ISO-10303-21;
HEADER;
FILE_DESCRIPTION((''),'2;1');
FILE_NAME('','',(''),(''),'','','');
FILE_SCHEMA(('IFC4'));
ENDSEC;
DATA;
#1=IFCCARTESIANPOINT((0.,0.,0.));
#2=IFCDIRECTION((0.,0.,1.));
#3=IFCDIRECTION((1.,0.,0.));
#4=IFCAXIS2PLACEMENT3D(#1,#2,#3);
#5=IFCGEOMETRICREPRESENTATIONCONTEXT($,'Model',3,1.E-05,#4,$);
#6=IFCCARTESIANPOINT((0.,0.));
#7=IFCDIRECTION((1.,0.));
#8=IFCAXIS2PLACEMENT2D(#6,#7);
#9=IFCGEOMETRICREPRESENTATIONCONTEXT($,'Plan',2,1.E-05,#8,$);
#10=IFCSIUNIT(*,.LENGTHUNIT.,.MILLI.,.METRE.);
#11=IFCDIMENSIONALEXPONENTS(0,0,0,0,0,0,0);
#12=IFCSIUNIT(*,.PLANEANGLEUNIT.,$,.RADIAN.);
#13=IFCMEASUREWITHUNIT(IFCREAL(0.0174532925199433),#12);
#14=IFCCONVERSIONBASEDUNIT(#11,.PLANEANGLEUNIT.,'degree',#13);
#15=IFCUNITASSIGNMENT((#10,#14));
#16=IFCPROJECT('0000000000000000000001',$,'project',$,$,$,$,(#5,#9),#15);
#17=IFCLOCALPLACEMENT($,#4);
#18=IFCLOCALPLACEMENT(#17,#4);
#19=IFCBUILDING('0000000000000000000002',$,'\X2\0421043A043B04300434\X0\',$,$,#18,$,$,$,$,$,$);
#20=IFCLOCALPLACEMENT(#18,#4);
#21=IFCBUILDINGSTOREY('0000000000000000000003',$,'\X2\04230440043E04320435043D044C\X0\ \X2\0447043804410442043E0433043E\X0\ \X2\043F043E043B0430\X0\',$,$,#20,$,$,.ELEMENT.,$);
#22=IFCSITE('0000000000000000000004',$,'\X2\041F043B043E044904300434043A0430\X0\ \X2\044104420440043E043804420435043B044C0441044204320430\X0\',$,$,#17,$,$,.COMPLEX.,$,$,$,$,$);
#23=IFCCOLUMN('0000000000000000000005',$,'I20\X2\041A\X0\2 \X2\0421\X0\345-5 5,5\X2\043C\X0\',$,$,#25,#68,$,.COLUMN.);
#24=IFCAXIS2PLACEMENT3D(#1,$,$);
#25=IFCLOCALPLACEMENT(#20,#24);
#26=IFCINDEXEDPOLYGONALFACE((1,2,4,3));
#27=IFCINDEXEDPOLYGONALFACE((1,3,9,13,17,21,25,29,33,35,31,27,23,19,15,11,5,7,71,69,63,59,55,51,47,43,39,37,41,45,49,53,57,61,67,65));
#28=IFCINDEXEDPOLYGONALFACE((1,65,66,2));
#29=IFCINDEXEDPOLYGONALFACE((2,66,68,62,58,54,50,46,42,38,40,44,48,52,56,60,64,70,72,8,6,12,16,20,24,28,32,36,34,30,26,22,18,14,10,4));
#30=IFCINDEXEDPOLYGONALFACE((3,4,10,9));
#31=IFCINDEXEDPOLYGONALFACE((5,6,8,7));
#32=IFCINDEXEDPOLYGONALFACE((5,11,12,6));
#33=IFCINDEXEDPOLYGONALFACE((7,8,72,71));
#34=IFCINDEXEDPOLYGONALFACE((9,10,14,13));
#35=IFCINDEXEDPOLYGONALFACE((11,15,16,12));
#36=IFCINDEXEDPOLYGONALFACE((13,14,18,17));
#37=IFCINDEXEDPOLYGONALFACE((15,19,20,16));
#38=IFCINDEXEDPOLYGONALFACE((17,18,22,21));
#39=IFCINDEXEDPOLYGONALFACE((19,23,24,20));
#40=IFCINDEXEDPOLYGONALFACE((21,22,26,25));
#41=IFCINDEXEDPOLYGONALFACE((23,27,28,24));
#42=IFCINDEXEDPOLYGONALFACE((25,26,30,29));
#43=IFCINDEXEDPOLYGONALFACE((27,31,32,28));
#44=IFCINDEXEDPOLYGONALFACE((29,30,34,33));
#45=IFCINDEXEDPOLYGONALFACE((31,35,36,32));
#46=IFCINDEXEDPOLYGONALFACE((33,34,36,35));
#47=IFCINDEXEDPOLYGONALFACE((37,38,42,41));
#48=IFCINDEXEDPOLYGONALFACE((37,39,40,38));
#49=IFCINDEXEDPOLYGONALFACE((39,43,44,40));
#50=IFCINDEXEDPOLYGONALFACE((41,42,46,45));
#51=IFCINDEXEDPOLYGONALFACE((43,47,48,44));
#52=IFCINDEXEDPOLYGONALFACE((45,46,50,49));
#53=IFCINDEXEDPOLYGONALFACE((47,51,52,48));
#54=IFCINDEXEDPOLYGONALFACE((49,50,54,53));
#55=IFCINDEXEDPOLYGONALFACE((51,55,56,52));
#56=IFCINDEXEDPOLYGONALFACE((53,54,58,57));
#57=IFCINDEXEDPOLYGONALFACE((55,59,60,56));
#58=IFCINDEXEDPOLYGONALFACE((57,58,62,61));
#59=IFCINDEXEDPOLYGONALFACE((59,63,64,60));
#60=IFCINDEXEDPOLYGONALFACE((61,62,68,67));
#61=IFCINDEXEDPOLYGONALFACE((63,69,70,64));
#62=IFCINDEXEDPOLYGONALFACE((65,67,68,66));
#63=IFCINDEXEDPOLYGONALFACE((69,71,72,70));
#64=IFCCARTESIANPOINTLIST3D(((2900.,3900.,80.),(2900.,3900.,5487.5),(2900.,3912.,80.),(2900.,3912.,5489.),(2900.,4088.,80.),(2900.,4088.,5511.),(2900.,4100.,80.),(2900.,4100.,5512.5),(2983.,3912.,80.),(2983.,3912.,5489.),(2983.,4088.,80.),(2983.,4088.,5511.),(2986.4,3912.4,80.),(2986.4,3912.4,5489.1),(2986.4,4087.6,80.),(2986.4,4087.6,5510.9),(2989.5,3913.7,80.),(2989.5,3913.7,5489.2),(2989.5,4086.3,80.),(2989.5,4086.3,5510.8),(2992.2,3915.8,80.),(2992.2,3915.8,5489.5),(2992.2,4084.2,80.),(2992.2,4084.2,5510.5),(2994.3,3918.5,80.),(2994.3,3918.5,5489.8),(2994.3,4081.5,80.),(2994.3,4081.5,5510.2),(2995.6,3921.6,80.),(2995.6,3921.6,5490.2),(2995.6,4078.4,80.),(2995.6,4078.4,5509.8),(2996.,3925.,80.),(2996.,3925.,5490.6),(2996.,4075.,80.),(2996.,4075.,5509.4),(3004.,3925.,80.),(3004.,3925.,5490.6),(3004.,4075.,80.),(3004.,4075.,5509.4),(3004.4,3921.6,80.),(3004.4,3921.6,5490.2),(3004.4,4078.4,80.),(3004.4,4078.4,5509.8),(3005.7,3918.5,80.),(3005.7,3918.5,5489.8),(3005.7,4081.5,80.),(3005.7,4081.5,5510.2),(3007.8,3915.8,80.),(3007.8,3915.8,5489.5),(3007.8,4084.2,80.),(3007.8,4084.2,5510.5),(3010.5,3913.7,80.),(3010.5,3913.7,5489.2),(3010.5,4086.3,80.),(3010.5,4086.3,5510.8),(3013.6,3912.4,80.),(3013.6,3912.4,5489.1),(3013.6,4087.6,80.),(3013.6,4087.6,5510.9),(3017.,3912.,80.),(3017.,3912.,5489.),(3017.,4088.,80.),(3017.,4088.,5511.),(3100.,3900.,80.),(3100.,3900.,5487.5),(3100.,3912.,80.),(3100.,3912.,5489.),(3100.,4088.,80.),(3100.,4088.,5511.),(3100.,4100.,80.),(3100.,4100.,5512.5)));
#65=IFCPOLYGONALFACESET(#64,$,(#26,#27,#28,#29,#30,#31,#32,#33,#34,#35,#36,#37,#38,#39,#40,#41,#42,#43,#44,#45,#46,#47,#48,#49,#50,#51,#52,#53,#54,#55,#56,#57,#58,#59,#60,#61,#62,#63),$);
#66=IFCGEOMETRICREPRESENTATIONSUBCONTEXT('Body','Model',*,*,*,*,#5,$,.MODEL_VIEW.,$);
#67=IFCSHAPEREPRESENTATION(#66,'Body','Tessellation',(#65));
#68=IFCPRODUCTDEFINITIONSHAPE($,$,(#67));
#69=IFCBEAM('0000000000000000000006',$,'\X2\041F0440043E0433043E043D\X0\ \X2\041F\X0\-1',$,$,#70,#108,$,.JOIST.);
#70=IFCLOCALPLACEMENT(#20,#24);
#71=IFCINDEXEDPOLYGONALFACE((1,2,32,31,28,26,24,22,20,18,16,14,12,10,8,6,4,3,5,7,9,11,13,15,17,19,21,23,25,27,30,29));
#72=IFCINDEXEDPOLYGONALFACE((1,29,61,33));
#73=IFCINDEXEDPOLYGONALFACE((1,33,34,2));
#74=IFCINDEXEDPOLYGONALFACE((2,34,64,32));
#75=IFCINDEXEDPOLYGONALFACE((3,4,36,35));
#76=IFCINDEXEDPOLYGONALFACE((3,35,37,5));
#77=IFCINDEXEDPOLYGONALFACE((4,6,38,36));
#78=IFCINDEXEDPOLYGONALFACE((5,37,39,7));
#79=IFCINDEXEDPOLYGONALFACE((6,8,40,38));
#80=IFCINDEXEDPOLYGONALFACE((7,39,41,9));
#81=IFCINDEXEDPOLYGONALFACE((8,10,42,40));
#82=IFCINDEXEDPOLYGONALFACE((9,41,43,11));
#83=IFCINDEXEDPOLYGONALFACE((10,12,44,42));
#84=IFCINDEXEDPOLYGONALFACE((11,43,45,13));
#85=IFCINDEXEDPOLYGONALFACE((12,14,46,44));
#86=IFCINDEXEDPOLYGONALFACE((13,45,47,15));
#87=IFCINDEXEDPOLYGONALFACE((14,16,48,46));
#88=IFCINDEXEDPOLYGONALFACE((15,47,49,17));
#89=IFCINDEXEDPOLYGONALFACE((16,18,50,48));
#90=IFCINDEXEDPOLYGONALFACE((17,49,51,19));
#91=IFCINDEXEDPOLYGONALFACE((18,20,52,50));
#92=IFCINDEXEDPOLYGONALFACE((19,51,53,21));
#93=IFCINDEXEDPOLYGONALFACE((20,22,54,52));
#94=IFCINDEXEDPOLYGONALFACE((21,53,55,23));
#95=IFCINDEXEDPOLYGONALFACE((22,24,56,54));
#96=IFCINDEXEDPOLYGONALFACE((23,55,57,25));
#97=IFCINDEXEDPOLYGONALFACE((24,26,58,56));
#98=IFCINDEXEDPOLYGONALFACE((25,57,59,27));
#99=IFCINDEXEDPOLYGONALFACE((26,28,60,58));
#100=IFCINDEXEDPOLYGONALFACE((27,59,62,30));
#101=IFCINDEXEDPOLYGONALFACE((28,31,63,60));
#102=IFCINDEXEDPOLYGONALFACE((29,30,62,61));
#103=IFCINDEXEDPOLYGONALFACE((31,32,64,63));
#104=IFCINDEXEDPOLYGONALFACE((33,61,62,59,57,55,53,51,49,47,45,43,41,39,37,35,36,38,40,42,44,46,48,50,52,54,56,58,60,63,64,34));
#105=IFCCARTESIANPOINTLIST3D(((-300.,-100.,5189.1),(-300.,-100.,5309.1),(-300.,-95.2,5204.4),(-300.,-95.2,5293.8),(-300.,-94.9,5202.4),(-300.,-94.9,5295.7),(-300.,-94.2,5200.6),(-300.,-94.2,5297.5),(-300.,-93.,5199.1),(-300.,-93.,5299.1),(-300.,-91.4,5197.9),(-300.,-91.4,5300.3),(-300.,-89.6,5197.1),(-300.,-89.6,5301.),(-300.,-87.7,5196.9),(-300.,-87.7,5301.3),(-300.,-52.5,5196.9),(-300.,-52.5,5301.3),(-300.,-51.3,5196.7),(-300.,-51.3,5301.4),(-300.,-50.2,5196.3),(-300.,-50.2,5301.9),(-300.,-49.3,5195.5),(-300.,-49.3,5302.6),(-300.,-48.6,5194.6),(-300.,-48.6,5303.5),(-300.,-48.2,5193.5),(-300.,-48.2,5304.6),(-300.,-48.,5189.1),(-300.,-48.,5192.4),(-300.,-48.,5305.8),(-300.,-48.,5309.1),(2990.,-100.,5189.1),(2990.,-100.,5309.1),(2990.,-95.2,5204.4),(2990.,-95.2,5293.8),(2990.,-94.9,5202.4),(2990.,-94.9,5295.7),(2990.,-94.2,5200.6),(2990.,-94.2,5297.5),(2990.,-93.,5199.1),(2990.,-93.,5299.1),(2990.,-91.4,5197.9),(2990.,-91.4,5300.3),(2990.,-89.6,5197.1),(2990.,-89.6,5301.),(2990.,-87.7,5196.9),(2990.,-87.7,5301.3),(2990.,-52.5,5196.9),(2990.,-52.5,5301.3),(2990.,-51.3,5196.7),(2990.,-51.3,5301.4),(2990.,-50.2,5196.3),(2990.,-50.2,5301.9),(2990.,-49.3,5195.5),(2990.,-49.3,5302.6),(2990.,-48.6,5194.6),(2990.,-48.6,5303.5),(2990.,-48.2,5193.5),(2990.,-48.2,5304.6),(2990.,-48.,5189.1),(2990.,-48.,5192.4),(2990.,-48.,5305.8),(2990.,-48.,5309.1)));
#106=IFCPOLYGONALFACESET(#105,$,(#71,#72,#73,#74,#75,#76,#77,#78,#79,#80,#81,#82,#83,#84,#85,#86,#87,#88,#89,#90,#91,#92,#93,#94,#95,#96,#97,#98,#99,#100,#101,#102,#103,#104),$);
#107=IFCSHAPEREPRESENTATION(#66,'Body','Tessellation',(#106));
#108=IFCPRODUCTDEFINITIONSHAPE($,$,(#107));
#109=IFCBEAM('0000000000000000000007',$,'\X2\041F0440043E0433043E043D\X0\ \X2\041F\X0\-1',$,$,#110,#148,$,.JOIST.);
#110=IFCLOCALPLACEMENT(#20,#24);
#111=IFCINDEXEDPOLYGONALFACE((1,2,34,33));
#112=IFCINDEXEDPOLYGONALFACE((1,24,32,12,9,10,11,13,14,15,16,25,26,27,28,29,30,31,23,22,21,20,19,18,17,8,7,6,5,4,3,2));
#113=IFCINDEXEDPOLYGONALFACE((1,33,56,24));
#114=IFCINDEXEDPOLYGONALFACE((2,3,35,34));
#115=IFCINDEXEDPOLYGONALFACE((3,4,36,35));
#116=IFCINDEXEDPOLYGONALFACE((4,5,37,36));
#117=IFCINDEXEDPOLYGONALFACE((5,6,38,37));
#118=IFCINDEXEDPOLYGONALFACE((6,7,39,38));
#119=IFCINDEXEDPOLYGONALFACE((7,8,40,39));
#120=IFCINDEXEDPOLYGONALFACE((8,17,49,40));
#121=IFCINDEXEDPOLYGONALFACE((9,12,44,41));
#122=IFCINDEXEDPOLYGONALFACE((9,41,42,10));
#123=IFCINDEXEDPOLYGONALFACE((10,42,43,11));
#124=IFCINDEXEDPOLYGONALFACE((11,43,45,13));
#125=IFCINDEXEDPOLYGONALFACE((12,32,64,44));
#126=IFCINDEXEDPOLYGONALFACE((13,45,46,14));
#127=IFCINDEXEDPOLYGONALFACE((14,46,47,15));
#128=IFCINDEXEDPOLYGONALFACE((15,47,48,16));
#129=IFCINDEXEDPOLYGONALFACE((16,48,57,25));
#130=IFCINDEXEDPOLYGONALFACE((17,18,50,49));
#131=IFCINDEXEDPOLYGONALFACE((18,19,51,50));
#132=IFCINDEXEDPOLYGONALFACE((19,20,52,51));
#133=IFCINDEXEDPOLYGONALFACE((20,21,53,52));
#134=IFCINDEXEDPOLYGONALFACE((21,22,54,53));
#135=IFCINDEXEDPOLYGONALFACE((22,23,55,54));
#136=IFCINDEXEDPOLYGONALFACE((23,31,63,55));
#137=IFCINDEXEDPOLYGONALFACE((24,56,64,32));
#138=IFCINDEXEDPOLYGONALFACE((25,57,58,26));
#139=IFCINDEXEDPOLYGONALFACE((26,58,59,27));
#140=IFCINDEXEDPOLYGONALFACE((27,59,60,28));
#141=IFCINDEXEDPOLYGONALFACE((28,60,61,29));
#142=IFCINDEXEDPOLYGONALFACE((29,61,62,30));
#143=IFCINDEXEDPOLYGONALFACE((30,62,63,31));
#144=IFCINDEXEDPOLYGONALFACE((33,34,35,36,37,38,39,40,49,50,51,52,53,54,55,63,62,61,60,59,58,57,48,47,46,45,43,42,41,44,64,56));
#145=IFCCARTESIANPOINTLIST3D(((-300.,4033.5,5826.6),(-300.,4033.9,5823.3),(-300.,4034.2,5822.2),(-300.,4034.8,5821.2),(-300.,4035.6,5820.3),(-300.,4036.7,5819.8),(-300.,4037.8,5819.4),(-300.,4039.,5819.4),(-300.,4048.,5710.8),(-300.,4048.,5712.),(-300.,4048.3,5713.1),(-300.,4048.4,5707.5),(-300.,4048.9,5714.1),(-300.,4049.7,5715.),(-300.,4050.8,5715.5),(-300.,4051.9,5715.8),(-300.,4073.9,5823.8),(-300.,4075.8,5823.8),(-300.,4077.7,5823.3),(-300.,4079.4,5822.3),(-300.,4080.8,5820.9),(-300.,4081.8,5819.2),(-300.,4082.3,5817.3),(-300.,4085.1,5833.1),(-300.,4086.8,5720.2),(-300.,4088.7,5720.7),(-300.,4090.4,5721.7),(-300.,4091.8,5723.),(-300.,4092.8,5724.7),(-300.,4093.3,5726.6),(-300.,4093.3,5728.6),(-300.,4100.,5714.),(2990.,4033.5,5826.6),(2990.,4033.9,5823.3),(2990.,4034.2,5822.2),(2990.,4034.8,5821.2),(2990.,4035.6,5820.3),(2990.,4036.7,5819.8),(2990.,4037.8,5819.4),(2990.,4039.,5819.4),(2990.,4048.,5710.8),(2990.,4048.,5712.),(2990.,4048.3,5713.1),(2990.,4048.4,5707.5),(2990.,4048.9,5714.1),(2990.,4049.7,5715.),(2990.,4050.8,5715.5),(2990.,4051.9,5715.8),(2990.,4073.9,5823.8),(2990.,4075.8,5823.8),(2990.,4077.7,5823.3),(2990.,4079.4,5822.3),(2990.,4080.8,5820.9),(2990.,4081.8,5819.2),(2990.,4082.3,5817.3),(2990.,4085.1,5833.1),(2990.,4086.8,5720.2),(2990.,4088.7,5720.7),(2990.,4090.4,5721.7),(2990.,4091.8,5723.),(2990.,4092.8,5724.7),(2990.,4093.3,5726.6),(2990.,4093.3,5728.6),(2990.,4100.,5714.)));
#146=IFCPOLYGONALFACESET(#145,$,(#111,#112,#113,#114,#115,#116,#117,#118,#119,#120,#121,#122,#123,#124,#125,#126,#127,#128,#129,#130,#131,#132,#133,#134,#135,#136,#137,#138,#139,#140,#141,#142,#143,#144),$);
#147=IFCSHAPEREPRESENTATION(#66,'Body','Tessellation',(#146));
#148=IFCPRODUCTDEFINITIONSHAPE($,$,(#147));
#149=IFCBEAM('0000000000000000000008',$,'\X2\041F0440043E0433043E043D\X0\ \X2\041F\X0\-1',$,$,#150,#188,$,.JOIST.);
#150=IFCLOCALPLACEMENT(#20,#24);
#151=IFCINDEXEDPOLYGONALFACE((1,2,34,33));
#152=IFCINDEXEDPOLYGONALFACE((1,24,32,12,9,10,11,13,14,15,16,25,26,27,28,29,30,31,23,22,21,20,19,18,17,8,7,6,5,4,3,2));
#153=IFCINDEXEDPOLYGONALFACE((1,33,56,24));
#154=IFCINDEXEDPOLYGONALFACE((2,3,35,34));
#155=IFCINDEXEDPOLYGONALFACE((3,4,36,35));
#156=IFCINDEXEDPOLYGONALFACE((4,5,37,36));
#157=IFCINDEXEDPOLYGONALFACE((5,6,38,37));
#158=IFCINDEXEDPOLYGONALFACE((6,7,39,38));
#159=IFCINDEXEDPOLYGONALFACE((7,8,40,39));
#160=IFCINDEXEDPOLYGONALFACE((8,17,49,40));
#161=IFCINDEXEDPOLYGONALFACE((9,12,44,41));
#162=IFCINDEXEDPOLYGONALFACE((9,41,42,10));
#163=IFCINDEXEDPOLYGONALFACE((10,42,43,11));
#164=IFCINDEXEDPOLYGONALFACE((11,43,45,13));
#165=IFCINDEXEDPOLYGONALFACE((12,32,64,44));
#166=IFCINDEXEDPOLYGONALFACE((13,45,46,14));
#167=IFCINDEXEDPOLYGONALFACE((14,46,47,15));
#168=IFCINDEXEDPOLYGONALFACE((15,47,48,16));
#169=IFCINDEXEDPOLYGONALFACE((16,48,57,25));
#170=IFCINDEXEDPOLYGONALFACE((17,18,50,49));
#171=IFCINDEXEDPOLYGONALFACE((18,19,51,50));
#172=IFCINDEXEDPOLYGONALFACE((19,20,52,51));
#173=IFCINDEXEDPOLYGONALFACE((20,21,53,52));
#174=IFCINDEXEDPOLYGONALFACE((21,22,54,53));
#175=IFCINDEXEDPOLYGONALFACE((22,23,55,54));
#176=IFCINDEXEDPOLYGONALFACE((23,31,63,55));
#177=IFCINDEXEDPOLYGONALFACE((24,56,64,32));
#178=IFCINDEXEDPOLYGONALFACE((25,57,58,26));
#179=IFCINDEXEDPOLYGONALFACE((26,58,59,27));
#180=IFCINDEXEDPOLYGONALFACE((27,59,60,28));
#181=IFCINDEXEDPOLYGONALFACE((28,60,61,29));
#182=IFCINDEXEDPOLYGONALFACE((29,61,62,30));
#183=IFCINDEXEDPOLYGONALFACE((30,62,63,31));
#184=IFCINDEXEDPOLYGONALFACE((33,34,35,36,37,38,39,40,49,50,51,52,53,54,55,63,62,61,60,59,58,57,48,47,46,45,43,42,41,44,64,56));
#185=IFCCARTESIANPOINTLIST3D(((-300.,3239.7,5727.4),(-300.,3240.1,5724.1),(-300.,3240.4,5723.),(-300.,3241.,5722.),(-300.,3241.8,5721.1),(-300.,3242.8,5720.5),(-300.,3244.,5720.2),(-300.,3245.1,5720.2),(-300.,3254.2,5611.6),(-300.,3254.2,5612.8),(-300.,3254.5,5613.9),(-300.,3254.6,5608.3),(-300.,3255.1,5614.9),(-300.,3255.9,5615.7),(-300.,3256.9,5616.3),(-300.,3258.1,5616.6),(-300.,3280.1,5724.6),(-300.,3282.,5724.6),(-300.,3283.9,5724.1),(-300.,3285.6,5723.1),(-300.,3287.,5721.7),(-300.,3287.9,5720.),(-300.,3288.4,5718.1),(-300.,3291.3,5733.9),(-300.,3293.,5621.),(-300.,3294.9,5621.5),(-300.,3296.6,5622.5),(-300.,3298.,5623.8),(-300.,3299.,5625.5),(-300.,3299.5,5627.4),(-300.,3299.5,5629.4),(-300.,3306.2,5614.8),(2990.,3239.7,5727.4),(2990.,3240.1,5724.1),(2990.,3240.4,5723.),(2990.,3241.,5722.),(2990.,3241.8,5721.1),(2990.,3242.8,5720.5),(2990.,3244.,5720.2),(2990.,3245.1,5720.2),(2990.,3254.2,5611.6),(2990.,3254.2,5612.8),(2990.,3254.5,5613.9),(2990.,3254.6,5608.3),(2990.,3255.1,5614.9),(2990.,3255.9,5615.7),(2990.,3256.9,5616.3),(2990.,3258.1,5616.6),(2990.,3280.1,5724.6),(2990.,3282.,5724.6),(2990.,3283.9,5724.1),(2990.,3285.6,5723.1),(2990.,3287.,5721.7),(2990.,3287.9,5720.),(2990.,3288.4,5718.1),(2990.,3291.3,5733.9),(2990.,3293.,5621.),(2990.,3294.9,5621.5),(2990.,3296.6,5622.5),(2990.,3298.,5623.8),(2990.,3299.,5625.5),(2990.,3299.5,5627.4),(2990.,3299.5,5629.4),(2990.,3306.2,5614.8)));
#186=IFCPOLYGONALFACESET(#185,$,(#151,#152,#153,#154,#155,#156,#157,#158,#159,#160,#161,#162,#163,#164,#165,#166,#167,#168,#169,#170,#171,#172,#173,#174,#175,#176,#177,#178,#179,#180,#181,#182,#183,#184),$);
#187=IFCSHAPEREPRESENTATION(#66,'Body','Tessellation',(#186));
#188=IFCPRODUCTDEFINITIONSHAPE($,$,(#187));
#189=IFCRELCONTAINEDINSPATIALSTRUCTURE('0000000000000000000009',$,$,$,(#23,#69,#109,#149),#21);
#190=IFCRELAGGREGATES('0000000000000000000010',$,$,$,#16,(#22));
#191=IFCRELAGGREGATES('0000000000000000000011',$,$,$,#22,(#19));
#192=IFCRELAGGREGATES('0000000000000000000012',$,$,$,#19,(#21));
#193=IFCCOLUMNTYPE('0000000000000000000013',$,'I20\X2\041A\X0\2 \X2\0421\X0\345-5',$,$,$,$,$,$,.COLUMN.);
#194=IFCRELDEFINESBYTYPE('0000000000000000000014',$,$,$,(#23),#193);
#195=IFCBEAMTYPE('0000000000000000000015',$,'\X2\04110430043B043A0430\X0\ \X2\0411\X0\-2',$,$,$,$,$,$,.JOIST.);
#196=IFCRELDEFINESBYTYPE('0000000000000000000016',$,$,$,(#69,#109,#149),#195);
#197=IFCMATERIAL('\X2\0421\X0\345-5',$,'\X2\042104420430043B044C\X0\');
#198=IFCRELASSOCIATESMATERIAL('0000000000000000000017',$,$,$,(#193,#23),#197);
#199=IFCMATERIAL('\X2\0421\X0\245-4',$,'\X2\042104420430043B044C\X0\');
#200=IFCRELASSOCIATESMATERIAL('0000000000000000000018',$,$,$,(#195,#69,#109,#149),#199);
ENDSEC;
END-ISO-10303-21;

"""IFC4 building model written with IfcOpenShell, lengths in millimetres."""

from ifc_helpers import new_model, entity, si_unit, converted_unit, frame, origin_with_axes, origin_2d_with_axis, place, context, subcontext, project, spatial, i_section, u_section, extrude, boolean, clip, halfspace, material, material_profile, profile_set, profile_usage, type_object, element, save


model = new_model("IFC4")

# Units and contexts
model_context = context("Model", 3, precision=1e-05, world=origin_with_axes())
plan_context = context("Plan", 2, precision=1e-05, world=origin_2d_with_axis())
body_context = subcontext(model_context, "Body", "Model", "MODEL_VIEW")
ifc_project = project(units=[si_unit("LENGTHUNIT", "METRE", prefix="MILLI"), converted_unit("PLANEANGLEUNIT", "degree", entity("IfcReal", 0.0174532925199433), si_unit("PLANEANGLEUNIT", "RADIAN"), dimensions=[0, 0, 0, 0, 0, 0, 0])], contexts=[model_context, plan_context])

# Site, building, storey
site_placement = place(None, origin_with_axes())
site = spatial("IfcSite", under=ifc_project, at=site_placement, Name="Площадка строительства", CompositionType="COMPLEX")
building_placement = place(site_placement, origin_with_axes())
building = spatial("IfcBuilding", under=site, at=building_placement, Name="Склад")
storey_placement = place(building_placement, origin_with_axes())
storey = spatial("IfcBuildingStorey", under=building, at=storey_placement, Name="Уровень чистого пола", CompositionType="ELEMENT")

# Shared definitions
ifc_material_1 = material(Name="С345-5", Category="Сталь")
ifc_material_profile_1 = material_profile(ifc_material_1, i_section(OverallWidth=200.0, OverallDepth=200.0, WebThickness=8.0, FlangeThickness=12.0, FilletRadius=13.0, FlangeEdgeRadius=0.0, FlangeSlope=0.0))
ifc_profile_set_1 = profile_set([ifc_material_profile_1], Name="I20К2_С345-5")
column_type = type_object("IfcColumnType", Name="I20К2 С345-5", PredefinedType="COLUMN", material=ifc_profile_set_1)

# Column
ifc_profile_usage_1 = profile_usage(ifc_profile_set_1, cardinal=5)
column_1_placement = place(storey_placement, frame((3000.0, 4000.0, 0.0), z_axis=(0.0, 0.0, 1.0), x_axis=(1.0, 0.0, 0.0)))
element("IfcColumn", 1, at=column_1_placement, inside=storey, type_object=column_type, material=ifc_profile_usage_1, Name="I20К2 С345-5 5,5м", PredefinedType="COLUMN", context=body_context, shape_type="Clipping", body=[
    boolean("DIFFERENCE", clip(extrude(i_section(OverallWidth=200.0, OverallDepth=200.0, WebThickness=8.0, FlangeThickness=12.0, FilletRadius=13.0, FlangeEdgeRadius=0.0, FlangeSlope=0.0), origin_with_axes(), (0.0, 0.0, 1.0), 5700.0), halfspace(frame((0.0, -4298.5, 4962.7), z_axis=(0.0, -0.124035, 0.992278), x_axis=(0.0, 0.992278, 0.124035)), False)), halfspace(frame((0.0, 0.0, 80.0), z_axis=(0.0, 0.0, -1.0), x_axis=(1.0, 0.0, 0.0)), False)),
])

# Beams
ifc_material_2 = material(Name="С245-4", Category="Сталь")
ifc_material_profile_2 = material_profile(ifc_material_2, u_section(Depth=120.0, FlangeWidth=52.0, WebThickness=4.8, FlangeThickness=7.8, FilletRadius=7.5, EdgeRadius=4.5, FlangeSlope=0.0))
ifc_profile_set_2 = profile_set([ifc_material_profile_2], Name="U12P_S245-4")
ifc_profile_usage_2 = profile_usage(ifc_profile_set_2, cardinal=3)
beam_type_1 = type_object("IfcBeamType", Name="Балка Б-2", PredefinedType="JOIST", material=ifc_profile_set_2)
beam_1_placement = place(storey_placement, frame((-300.0, -100.0, 5189.1), z_axis=(1.0, 0.0, 0.0), x_axis=(0.0, 1.0, 0.0)))
element("IfcBeam", 2, at=beam_1_placement, inside=storey, type_object=beam_type_1, material=ifc_profile_usage_2, Name="Прогон П-1", PredefinedType="JOIST", context=body_context, shape_type="SweptSolid", body=[
    extrude(u_section(Depth=120.0, FlangeWidth=52.0, WebThickness=4.8, FlangeThickness=7.8, FilletRadius=7.5, EdgeRadius=4.5, FlangeSlope=0.0), frame((26.0, 60.0, 0.0), z_axis=(0.0, 0.0, 1.0), x_axis=(1.0, 0.0, 0.0)), (0.0, 0.0, 1.0), 3290.0),
])
ifc_profile_usage_3 = profile_usage(ifc_profile_set_2, cardinal=3)
beam_2_placement = place(storey_placement, frame((2990.0, 4100.0, 5714.0), z_axis=(-1.0, 0.0, 0.0), x_axis=(0.0, -0.99228, -0.124019)))
element("IfcBeam", 3, at=beam_2_placement, inside=storey, type_object=beam_type_1, material=ifc_profile_usage_3, Name="Прогон П-1", PredefinedType="JOIST", context=body_context, shape_type="SweptSolid", body=[
    extrude(u_section(Depth=120.0, FlangeWidth=52.0, WebThickness=4.8, FlangeThickness=7.8, FilletRadius=7.5, EdgeRadius=4.5, FlangeSlope=0.0), frame((26.0, 60.0, 0.0), z_axis=(0.0, 0.0, 1.0), x_axis=(1.0, 0.0, 0.0)), (0.0, 0.0, 1.0), 3290.0),
])
ifc_profile_usage_4 = profile_usage(ifc_profile_set_2, cardinal=3)
beam_3_placement = place(storey_placement, frame((2990.0, 3306.2, 5614.8), z_axis=(-1.0, 0.0, 0.0), x_axis=(0.0, -0.99228, -0.124019)))
element("IfcBeam", 4, at=beam_3_placement, inside=storey, type_object=beam_type_1, material=ifc_profile_usage_4, Name="Прогон П-1", PredefinedType="JOIST", context=body_context, shape_type="SweptSolid", body=[
    extrude(u_section(Depth=120.0, FlangeWidth=52.0, WebThickness=4.8, FlangeThickness=7.8, FilletRadius=7.5, EdgeRadius=4.5, FlangeSlope=0.0), frame((26.0, 60.0, 0.0), z_axis=(0.0, 0.0, 1.0), x_axis=(1.0, 0.0, 0.0)), (0.0, 0.0, 1.0), 3290.0),
])

save(model, "model.ifc")
